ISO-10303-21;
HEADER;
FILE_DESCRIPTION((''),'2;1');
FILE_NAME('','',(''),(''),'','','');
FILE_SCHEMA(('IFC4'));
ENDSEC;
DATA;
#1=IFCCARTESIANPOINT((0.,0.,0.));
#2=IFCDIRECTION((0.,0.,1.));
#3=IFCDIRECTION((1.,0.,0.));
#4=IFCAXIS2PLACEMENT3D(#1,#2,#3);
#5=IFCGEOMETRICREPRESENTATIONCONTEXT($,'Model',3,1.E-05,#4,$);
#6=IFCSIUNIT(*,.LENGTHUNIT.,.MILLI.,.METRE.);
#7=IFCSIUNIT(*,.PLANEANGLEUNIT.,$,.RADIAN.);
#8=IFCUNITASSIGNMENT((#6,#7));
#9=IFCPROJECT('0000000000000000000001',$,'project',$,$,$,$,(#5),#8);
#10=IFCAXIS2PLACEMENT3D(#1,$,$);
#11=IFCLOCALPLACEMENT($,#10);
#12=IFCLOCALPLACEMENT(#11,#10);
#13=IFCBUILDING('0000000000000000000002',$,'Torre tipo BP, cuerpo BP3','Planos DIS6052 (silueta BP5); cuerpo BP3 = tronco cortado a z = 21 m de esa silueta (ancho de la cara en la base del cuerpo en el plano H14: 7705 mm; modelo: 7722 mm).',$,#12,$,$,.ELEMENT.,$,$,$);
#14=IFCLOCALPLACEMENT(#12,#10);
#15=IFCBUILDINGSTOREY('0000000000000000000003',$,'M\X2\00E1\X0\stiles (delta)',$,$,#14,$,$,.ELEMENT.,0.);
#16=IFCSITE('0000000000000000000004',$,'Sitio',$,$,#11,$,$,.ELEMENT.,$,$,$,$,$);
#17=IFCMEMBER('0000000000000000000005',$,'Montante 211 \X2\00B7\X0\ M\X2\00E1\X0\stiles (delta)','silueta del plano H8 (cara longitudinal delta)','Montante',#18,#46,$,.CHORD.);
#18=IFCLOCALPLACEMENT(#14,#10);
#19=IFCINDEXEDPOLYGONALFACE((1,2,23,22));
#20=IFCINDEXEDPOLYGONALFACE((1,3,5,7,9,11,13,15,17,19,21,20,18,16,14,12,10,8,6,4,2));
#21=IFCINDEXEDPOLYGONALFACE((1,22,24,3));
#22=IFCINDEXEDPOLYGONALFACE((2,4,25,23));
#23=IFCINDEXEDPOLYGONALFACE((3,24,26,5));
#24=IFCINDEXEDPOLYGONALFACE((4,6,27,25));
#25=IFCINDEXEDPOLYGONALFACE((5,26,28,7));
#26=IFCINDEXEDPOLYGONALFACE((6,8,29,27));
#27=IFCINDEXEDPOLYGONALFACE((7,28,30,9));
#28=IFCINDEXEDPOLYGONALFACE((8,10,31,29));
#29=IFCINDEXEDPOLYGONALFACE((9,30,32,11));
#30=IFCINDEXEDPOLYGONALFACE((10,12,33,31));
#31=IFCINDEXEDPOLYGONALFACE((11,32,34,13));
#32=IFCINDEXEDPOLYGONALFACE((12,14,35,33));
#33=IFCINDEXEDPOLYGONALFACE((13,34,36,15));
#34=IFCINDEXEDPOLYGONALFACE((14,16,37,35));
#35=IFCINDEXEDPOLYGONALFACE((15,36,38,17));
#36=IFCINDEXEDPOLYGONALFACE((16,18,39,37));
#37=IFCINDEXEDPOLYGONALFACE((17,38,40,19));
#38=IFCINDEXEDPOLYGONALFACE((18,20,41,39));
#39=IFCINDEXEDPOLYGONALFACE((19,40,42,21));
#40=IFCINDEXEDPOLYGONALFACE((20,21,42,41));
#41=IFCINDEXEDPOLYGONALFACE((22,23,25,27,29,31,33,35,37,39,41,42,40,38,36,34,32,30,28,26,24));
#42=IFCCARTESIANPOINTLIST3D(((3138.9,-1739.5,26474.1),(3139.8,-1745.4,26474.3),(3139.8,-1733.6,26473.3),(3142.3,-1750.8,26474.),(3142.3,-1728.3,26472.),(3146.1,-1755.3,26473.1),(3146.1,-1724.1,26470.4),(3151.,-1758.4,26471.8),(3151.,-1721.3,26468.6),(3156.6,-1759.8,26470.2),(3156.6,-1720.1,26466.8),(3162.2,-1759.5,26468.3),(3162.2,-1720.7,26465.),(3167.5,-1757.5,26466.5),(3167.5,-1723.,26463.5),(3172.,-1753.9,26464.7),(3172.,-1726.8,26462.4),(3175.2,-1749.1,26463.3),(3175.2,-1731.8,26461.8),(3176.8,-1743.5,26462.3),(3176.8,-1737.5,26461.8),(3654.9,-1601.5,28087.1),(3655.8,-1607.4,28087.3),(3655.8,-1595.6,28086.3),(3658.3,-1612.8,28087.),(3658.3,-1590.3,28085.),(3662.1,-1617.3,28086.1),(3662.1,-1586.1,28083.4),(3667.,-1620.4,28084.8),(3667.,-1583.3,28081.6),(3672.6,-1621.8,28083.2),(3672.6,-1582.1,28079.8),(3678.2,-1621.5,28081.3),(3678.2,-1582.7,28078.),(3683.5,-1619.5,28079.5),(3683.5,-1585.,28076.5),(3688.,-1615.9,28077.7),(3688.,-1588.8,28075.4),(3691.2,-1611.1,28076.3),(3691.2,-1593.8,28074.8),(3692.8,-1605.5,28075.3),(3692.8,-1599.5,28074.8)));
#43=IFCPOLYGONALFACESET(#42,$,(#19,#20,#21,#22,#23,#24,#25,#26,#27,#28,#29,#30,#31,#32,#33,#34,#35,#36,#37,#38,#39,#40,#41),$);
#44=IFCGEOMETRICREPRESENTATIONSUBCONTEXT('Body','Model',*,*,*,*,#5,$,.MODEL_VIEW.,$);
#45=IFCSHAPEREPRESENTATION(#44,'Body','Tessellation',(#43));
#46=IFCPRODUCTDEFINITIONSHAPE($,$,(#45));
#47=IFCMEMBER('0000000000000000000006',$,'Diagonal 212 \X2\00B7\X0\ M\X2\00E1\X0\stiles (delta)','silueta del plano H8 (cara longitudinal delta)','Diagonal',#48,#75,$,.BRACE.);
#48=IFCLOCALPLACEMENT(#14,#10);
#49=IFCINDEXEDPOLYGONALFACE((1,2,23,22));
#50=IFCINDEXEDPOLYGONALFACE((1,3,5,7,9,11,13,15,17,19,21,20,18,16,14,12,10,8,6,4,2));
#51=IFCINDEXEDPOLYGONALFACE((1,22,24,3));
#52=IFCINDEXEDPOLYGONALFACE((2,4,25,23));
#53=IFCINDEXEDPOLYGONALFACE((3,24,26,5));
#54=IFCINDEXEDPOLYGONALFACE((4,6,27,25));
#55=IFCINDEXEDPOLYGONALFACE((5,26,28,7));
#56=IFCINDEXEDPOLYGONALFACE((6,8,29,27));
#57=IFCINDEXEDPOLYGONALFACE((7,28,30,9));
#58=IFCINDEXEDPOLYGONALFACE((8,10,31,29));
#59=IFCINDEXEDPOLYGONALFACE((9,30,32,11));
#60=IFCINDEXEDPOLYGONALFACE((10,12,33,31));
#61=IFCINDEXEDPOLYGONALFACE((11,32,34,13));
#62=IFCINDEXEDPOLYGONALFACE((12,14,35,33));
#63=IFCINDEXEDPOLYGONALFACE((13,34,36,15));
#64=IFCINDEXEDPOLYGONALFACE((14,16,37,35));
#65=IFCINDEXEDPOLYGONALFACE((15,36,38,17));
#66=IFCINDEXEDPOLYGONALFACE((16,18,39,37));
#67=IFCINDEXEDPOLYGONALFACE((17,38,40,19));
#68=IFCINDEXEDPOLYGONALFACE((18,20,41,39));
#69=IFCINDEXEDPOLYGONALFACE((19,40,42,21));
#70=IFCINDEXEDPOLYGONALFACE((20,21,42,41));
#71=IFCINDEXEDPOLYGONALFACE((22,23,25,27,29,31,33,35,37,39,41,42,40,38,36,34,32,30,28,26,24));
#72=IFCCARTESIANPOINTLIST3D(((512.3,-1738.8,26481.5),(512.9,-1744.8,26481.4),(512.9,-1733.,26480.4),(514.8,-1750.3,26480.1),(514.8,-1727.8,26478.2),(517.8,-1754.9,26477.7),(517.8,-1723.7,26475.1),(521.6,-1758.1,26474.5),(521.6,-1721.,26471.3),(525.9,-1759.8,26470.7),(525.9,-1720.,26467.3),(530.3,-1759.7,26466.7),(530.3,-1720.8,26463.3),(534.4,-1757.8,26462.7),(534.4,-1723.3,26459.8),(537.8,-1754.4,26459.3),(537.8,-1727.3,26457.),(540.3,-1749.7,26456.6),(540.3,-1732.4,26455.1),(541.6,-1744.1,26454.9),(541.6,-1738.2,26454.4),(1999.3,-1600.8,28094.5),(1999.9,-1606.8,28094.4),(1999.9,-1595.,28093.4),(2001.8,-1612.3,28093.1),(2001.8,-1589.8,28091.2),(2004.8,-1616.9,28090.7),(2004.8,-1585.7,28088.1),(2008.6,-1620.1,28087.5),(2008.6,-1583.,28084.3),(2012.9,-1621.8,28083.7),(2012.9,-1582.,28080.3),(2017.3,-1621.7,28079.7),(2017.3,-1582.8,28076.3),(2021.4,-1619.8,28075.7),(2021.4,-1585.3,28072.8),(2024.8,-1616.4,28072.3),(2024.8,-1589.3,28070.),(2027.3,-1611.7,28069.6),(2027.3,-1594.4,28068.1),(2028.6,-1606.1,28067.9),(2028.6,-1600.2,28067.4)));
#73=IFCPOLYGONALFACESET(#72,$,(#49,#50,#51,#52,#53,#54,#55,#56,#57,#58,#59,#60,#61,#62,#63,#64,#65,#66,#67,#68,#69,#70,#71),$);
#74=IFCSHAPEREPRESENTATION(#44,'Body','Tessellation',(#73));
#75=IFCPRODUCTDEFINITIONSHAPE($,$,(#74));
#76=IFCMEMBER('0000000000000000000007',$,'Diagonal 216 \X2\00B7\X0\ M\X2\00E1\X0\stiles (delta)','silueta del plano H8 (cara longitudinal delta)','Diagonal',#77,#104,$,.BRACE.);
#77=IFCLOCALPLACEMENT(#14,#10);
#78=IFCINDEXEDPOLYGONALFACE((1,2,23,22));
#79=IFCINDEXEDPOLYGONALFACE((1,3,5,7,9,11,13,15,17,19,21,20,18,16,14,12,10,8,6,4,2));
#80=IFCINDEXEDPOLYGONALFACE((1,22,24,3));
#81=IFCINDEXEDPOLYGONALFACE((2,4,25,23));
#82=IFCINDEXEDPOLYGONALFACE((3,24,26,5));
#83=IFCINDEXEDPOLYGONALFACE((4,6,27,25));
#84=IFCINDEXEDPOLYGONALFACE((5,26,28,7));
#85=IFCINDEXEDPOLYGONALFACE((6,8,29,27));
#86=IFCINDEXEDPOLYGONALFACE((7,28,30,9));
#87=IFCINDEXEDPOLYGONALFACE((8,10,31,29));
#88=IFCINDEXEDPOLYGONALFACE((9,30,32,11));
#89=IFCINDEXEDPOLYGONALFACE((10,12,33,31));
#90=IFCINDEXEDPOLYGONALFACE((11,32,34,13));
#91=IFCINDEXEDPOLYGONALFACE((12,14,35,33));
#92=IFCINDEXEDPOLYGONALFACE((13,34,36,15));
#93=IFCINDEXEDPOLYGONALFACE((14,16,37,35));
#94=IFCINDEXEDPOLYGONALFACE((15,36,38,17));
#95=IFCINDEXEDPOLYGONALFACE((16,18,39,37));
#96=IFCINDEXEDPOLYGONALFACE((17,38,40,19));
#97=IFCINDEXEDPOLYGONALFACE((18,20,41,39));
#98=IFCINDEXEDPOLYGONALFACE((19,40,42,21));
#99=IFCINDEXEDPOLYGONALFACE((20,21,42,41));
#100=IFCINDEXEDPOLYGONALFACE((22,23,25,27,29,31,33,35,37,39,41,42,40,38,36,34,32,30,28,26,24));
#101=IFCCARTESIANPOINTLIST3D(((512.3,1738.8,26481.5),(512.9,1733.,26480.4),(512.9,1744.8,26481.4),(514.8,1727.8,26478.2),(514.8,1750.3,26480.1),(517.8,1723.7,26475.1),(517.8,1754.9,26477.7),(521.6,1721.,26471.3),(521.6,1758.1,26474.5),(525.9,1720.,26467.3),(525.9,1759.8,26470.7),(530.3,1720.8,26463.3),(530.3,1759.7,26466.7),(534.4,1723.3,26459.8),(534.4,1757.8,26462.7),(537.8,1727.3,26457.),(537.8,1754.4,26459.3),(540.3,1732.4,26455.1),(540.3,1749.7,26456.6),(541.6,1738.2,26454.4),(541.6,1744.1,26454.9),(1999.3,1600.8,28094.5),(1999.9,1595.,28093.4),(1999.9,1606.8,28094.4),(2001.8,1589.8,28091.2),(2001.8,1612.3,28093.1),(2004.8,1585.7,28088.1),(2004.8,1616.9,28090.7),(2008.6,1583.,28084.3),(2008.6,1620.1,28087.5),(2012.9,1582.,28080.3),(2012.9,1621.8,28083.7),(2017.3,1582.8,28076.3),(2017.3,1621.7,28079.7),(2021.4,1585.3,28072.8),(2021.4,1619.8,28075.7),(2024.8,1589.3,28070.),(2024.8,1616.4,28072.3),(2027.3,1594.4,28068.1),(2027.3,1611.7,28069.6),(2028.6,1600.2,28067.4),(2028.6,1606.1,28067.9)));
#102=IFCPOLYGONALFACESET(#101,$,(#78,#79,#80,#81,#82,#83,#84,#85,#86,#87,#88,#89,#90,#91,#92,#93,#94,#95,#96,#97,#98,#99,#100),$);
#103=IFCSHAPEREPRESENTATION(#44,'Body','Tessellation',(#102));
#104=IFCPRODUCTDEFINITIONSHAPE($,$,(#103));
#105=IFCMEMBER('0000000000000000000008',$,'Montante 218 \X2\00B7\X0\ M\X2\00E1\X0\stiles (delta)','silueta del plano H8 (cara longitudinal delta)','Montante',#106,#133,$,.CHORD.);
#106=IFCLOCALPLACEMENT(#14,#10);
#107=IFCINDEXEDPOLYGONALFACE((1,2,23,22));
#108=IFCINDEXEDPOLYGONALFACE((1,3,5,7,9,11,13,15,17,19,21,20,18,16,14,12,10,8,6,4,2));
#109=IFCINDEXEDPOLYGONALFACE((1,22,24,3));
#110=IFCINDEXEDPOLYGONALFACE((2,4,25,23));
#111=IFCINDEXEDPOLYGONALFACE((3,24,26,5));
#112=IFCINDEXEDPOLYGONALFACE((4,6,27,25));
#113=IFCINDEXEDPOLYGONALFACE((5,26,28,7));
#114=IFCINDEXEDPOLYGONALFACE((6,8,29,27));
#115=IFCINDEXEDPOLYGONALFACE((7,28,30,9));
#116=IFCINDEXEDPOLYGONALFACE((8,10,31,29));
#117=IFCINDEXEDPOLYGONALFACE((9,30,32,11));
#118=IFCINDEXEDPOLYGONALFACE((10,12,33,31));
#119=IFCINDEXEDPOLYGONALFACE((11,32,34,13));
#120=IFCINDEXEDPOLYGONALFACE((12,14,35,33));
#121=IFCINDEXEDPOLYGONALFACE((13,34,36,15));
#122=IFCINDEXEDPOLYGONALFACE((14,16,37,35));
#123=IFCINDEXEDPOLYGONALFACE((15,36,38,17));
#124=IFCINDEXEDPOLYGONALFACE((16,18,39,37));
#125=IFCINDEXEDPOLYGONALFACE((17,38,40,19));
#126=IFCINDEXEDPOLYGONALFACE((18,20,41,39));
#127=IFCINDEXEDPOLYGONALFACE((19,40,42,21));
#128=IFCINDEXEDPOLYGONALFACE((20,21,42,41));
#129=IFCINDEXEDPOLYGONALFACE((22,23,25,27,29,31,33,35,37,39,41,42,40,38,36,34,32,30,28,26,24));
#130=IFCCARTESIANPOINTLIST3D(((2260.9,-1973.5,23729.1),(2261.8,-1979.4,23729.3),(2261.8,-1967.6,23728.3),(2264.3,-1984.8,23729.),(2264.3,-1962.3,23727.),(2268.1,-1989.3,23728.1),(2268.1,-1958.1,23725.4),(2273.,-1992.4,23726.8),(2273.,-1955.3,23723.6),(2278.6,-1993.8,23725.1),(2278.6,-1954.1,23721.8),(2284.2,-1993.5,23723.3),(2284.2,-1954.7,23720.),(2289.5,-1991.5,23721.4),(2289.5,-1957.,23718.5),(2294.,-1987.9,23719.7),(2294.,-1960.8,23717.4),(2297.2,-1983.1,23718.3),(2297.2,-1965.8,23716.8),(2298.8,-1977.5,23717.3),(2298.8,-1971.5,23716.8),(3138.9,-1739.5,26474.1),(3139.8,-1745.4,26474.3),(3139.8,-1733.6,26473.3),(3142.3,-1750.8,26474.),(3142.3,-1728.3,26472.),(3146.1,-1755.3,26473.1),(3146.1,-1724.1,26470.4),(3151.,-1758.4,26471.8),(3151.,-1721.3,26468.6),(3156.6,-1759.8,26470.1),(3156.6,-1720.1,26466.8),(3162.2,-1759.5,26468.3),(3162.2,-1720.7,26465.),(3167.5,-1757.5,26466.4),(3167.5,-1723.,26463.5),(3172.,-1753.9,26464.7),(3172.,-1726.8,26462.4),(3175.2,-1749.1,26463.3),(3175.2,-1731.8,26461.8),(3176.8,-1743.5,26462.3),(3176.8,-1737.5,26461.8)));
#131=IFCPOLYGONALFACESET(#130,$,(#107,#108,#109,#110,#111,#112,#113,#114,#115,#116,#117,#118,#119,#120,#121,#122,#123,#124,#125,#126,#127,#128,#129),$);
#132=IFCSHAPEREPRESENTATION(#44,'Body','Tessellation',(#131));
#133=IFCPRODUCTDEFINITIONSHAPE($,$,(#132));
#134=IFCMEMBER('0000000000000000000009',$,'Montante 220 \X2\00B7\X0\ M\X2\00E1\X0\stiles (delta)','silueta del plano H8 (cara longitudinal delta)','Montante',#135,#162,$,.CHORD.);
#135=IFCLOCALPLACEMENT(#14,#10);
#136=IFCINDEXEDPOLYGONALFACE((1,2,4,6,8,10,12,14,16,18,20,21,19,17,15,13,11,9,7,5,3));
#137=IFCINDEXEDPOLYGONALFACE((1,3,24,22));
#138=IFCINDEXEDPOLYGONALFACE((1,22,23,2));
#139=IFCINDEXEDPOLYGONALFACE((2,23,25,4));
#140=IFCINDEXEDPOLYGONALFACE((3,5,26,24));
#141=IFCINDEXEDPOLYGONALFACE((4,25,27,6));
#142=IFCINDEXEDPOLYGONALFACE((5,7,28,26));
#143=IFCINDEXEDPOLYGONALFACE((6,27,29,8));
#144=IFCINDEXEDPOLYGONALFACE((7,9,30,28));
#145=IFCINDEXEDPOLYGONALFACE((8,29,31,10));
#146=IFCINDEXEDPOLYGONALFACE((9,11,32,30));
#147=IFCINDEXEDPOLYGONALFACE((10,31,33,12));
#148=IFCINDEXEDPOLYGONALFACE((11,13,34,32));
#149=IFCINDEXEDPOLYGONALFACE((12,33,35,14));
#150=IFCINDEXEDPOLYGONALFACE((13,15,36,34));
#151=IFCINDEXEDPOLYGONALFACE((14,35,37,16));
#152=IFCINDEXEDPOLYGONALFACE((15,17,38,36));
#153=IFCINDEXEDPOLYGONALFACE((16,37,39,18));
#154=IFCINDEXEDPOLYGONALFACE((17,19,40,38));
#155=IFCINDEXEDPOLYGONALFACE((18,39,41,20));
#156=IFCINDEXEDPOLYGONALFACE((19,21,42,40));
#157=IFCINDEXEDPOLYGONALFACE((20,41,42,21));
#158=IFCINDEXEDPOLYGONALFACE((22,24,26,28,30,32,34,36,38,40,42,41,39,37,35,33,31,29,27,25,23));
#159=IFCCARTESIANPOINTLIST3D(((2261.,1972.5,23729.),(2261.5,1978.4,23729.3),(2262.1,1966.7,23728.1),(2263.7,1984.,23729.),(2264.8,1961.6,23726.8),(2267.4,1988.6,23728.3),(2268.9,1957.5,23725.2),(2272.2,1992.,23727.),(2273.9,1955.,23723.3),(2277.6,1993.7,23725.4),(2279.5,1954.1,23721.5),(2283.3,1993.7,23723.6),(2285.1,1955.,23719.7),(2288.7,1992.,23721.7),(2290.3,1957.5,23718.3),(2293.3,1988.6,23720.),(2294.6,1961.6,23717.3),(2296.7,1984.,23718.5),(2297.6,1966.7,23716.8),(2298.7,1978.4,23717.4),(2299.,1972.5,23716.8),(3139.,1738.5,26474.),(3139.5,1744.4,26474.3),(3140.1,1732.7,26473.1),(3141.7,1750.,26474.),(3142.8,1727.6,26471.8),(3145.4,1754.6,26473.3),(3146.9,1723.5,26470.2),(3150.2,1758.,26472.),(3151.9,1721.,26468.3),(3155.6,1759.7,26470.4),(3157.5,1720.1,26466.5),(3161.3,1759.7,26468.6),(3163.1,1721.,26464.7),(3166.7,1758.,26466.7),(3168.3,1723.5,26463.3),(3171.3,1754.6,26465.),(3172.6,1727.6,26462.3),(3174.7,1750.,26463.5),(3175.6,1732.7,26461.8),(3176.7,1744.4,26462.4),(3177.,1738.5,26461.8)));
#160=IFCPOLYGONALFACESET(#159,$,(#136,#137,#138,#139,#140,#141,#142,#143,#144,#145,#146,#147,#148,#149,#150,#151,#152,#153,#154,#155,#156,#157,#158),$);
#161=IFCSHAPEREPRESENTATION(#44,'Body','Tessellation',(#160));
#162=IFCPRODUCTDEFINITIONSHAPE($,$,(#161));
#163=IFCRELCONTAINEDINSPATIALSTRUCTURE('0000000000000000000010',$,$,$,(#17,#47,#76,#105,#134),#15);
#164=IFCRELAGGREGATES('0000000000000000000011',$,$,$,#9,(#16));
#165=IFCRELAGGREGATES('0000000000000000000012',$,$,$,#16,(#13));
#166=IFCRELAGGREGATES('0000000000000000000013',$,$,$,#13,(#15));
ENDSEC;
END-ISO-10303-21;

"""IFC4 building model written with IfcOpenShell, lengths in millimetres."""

from ifc_helpers import new_model, si_unit, frame, origin, origin_with_axes, place, context, subcontext, project, spatial, circle, extrude, element, save


model = new_model("IFC4")

# Units and contexts
model_context = context("Model", 3, precision=1e-05, world=origin_with_axes())
body_context = subcontext(model_context, "Body", "Model", "MODEL_VIEW")
ifc_project = project(units=[si_unit("LENGTHUNIT", "METRE", prefix="MILLI"), si_unit("PLANEANGLEUNIT", "RADIAN")], contexts=[model_context])

# Site, building, storey
site_placement = place(None, origin())
site = spatial("IfcSite", under=ifc_project, at=site_placement, Name="Sitio", CompositionType="ELEMENT")
building_placement = place(site_placement, origin())
building = spatial("IfcBuilding", under=site, at=building_placement, Name="Torre tipo BP, cuerpo BP3", Description="Planos DIS6052 (silueta BP5); cuerpo BP3 = tronco cortado a z = 21 m de esa silueta (ancho de la cara en la base del cuerpo en el plano H14: 7705 mm; modelo: 7722 mm).", CompositionType="ELEMENT")
storey_placement = place(building_placement, origin())
storey = spatial("IfcBuildingStorey", under=building, at=storey_placement, Name="Mástiles (delta)", CompositionType="ELEMENT", Elevation=0.0)

# Members
member_1_placement = place(storey_placement, frame((3674.0, -1602.0, 28081.0), z_axis=(-0.303683, -0.081218, -0.949305), x_axis=(-0.952773, 0.025887, 0.302578)))
element("IfcMember", 1, at=member_1_placement, inside=storey, Name="Montante 211 · Mástiles (delta)", Description="silueta del plano H8 (cara longitudinal delta)", ObjectType="Montante", PredefinedType="CHORD", context=body_context, shape_type="SweptSolid", body=[
    extrude(circle(Radius=20.0), None, (0.0, 0.0, 1.0), 1699.1),
])
member_2_placement = place(storey_placement, frame((2014.0, -1602.0, 28081.0), z_axis=(-0.67647, -0.062779, -0.73379), x_axis=(-0.736471, 0.057665, 0.674007)))
element("IfcMember", 2, at=member_2_placement, inside=storey, Name="Diagonal 212 · Mástiles (delta)", Description="silueta del plano H8 (cara longitudinal delta)", ObjectType="Diagonal", PredefinedType="BRACE", context=body_context, shape_type="SweptSolid", body=[
    extrude(circle(Radius=20.0), None, (0.0, 0.0, 1.0), 2198.2),
])
member_3_placement = place(storey_placement, frame((2014.0, 1602.0, 28081.0), z_axis=(-0.67647, 0.062779, -0.73379), x_axis=(-0.736471, -0.057665, 0.674007)))
element("IfcMember", 3, at=member_3_placement, inside=storey, Name="Diagonal 216 · Mástiles (delta)", Description="silueta del plano H8 (cara longitudinal delta)", ObjectType="Diagonal", PredefinedType="BRACE", context=body_context, shape_type="SweptSolid", body=[
    extrude(circle(Radius=20.0), None, (0.0, 0.0, 1.0), 2198.2),
])
for number, where, z_axis, x_axis, name in (
    (4, (3158.0, -1740.0, 26468.0), (-0.303651, -0.080927, -0.94934), (-0.952783, 0.025791, 0.302553), "Montante 218 · Mástiles (delta)"),
    (5, (3158.0, 1740.0, 26468.0), (-0.303651, 0.080927, -0.94934), (-0.024655, -0.99672, -0.07708), "Montante 220 · Mástiles (delta)"),
):
    element("IfcMember", number, at=place(storey_placement, frame(where, z_axis=z_axis, x_axis=x_axis)), inside=storey, Name=name, Description="silueta del plano H8 (cara longitudinal delta)", ObjectType="Montante", PredefinedType="CHORD", context=body_context, shape_type="SweptSolid", body=[
        extrude(circle(Radius=20.0), None, (0.0, 0.0, 1.0), 2891.5),
    ])

save(model, "model.ifc")
